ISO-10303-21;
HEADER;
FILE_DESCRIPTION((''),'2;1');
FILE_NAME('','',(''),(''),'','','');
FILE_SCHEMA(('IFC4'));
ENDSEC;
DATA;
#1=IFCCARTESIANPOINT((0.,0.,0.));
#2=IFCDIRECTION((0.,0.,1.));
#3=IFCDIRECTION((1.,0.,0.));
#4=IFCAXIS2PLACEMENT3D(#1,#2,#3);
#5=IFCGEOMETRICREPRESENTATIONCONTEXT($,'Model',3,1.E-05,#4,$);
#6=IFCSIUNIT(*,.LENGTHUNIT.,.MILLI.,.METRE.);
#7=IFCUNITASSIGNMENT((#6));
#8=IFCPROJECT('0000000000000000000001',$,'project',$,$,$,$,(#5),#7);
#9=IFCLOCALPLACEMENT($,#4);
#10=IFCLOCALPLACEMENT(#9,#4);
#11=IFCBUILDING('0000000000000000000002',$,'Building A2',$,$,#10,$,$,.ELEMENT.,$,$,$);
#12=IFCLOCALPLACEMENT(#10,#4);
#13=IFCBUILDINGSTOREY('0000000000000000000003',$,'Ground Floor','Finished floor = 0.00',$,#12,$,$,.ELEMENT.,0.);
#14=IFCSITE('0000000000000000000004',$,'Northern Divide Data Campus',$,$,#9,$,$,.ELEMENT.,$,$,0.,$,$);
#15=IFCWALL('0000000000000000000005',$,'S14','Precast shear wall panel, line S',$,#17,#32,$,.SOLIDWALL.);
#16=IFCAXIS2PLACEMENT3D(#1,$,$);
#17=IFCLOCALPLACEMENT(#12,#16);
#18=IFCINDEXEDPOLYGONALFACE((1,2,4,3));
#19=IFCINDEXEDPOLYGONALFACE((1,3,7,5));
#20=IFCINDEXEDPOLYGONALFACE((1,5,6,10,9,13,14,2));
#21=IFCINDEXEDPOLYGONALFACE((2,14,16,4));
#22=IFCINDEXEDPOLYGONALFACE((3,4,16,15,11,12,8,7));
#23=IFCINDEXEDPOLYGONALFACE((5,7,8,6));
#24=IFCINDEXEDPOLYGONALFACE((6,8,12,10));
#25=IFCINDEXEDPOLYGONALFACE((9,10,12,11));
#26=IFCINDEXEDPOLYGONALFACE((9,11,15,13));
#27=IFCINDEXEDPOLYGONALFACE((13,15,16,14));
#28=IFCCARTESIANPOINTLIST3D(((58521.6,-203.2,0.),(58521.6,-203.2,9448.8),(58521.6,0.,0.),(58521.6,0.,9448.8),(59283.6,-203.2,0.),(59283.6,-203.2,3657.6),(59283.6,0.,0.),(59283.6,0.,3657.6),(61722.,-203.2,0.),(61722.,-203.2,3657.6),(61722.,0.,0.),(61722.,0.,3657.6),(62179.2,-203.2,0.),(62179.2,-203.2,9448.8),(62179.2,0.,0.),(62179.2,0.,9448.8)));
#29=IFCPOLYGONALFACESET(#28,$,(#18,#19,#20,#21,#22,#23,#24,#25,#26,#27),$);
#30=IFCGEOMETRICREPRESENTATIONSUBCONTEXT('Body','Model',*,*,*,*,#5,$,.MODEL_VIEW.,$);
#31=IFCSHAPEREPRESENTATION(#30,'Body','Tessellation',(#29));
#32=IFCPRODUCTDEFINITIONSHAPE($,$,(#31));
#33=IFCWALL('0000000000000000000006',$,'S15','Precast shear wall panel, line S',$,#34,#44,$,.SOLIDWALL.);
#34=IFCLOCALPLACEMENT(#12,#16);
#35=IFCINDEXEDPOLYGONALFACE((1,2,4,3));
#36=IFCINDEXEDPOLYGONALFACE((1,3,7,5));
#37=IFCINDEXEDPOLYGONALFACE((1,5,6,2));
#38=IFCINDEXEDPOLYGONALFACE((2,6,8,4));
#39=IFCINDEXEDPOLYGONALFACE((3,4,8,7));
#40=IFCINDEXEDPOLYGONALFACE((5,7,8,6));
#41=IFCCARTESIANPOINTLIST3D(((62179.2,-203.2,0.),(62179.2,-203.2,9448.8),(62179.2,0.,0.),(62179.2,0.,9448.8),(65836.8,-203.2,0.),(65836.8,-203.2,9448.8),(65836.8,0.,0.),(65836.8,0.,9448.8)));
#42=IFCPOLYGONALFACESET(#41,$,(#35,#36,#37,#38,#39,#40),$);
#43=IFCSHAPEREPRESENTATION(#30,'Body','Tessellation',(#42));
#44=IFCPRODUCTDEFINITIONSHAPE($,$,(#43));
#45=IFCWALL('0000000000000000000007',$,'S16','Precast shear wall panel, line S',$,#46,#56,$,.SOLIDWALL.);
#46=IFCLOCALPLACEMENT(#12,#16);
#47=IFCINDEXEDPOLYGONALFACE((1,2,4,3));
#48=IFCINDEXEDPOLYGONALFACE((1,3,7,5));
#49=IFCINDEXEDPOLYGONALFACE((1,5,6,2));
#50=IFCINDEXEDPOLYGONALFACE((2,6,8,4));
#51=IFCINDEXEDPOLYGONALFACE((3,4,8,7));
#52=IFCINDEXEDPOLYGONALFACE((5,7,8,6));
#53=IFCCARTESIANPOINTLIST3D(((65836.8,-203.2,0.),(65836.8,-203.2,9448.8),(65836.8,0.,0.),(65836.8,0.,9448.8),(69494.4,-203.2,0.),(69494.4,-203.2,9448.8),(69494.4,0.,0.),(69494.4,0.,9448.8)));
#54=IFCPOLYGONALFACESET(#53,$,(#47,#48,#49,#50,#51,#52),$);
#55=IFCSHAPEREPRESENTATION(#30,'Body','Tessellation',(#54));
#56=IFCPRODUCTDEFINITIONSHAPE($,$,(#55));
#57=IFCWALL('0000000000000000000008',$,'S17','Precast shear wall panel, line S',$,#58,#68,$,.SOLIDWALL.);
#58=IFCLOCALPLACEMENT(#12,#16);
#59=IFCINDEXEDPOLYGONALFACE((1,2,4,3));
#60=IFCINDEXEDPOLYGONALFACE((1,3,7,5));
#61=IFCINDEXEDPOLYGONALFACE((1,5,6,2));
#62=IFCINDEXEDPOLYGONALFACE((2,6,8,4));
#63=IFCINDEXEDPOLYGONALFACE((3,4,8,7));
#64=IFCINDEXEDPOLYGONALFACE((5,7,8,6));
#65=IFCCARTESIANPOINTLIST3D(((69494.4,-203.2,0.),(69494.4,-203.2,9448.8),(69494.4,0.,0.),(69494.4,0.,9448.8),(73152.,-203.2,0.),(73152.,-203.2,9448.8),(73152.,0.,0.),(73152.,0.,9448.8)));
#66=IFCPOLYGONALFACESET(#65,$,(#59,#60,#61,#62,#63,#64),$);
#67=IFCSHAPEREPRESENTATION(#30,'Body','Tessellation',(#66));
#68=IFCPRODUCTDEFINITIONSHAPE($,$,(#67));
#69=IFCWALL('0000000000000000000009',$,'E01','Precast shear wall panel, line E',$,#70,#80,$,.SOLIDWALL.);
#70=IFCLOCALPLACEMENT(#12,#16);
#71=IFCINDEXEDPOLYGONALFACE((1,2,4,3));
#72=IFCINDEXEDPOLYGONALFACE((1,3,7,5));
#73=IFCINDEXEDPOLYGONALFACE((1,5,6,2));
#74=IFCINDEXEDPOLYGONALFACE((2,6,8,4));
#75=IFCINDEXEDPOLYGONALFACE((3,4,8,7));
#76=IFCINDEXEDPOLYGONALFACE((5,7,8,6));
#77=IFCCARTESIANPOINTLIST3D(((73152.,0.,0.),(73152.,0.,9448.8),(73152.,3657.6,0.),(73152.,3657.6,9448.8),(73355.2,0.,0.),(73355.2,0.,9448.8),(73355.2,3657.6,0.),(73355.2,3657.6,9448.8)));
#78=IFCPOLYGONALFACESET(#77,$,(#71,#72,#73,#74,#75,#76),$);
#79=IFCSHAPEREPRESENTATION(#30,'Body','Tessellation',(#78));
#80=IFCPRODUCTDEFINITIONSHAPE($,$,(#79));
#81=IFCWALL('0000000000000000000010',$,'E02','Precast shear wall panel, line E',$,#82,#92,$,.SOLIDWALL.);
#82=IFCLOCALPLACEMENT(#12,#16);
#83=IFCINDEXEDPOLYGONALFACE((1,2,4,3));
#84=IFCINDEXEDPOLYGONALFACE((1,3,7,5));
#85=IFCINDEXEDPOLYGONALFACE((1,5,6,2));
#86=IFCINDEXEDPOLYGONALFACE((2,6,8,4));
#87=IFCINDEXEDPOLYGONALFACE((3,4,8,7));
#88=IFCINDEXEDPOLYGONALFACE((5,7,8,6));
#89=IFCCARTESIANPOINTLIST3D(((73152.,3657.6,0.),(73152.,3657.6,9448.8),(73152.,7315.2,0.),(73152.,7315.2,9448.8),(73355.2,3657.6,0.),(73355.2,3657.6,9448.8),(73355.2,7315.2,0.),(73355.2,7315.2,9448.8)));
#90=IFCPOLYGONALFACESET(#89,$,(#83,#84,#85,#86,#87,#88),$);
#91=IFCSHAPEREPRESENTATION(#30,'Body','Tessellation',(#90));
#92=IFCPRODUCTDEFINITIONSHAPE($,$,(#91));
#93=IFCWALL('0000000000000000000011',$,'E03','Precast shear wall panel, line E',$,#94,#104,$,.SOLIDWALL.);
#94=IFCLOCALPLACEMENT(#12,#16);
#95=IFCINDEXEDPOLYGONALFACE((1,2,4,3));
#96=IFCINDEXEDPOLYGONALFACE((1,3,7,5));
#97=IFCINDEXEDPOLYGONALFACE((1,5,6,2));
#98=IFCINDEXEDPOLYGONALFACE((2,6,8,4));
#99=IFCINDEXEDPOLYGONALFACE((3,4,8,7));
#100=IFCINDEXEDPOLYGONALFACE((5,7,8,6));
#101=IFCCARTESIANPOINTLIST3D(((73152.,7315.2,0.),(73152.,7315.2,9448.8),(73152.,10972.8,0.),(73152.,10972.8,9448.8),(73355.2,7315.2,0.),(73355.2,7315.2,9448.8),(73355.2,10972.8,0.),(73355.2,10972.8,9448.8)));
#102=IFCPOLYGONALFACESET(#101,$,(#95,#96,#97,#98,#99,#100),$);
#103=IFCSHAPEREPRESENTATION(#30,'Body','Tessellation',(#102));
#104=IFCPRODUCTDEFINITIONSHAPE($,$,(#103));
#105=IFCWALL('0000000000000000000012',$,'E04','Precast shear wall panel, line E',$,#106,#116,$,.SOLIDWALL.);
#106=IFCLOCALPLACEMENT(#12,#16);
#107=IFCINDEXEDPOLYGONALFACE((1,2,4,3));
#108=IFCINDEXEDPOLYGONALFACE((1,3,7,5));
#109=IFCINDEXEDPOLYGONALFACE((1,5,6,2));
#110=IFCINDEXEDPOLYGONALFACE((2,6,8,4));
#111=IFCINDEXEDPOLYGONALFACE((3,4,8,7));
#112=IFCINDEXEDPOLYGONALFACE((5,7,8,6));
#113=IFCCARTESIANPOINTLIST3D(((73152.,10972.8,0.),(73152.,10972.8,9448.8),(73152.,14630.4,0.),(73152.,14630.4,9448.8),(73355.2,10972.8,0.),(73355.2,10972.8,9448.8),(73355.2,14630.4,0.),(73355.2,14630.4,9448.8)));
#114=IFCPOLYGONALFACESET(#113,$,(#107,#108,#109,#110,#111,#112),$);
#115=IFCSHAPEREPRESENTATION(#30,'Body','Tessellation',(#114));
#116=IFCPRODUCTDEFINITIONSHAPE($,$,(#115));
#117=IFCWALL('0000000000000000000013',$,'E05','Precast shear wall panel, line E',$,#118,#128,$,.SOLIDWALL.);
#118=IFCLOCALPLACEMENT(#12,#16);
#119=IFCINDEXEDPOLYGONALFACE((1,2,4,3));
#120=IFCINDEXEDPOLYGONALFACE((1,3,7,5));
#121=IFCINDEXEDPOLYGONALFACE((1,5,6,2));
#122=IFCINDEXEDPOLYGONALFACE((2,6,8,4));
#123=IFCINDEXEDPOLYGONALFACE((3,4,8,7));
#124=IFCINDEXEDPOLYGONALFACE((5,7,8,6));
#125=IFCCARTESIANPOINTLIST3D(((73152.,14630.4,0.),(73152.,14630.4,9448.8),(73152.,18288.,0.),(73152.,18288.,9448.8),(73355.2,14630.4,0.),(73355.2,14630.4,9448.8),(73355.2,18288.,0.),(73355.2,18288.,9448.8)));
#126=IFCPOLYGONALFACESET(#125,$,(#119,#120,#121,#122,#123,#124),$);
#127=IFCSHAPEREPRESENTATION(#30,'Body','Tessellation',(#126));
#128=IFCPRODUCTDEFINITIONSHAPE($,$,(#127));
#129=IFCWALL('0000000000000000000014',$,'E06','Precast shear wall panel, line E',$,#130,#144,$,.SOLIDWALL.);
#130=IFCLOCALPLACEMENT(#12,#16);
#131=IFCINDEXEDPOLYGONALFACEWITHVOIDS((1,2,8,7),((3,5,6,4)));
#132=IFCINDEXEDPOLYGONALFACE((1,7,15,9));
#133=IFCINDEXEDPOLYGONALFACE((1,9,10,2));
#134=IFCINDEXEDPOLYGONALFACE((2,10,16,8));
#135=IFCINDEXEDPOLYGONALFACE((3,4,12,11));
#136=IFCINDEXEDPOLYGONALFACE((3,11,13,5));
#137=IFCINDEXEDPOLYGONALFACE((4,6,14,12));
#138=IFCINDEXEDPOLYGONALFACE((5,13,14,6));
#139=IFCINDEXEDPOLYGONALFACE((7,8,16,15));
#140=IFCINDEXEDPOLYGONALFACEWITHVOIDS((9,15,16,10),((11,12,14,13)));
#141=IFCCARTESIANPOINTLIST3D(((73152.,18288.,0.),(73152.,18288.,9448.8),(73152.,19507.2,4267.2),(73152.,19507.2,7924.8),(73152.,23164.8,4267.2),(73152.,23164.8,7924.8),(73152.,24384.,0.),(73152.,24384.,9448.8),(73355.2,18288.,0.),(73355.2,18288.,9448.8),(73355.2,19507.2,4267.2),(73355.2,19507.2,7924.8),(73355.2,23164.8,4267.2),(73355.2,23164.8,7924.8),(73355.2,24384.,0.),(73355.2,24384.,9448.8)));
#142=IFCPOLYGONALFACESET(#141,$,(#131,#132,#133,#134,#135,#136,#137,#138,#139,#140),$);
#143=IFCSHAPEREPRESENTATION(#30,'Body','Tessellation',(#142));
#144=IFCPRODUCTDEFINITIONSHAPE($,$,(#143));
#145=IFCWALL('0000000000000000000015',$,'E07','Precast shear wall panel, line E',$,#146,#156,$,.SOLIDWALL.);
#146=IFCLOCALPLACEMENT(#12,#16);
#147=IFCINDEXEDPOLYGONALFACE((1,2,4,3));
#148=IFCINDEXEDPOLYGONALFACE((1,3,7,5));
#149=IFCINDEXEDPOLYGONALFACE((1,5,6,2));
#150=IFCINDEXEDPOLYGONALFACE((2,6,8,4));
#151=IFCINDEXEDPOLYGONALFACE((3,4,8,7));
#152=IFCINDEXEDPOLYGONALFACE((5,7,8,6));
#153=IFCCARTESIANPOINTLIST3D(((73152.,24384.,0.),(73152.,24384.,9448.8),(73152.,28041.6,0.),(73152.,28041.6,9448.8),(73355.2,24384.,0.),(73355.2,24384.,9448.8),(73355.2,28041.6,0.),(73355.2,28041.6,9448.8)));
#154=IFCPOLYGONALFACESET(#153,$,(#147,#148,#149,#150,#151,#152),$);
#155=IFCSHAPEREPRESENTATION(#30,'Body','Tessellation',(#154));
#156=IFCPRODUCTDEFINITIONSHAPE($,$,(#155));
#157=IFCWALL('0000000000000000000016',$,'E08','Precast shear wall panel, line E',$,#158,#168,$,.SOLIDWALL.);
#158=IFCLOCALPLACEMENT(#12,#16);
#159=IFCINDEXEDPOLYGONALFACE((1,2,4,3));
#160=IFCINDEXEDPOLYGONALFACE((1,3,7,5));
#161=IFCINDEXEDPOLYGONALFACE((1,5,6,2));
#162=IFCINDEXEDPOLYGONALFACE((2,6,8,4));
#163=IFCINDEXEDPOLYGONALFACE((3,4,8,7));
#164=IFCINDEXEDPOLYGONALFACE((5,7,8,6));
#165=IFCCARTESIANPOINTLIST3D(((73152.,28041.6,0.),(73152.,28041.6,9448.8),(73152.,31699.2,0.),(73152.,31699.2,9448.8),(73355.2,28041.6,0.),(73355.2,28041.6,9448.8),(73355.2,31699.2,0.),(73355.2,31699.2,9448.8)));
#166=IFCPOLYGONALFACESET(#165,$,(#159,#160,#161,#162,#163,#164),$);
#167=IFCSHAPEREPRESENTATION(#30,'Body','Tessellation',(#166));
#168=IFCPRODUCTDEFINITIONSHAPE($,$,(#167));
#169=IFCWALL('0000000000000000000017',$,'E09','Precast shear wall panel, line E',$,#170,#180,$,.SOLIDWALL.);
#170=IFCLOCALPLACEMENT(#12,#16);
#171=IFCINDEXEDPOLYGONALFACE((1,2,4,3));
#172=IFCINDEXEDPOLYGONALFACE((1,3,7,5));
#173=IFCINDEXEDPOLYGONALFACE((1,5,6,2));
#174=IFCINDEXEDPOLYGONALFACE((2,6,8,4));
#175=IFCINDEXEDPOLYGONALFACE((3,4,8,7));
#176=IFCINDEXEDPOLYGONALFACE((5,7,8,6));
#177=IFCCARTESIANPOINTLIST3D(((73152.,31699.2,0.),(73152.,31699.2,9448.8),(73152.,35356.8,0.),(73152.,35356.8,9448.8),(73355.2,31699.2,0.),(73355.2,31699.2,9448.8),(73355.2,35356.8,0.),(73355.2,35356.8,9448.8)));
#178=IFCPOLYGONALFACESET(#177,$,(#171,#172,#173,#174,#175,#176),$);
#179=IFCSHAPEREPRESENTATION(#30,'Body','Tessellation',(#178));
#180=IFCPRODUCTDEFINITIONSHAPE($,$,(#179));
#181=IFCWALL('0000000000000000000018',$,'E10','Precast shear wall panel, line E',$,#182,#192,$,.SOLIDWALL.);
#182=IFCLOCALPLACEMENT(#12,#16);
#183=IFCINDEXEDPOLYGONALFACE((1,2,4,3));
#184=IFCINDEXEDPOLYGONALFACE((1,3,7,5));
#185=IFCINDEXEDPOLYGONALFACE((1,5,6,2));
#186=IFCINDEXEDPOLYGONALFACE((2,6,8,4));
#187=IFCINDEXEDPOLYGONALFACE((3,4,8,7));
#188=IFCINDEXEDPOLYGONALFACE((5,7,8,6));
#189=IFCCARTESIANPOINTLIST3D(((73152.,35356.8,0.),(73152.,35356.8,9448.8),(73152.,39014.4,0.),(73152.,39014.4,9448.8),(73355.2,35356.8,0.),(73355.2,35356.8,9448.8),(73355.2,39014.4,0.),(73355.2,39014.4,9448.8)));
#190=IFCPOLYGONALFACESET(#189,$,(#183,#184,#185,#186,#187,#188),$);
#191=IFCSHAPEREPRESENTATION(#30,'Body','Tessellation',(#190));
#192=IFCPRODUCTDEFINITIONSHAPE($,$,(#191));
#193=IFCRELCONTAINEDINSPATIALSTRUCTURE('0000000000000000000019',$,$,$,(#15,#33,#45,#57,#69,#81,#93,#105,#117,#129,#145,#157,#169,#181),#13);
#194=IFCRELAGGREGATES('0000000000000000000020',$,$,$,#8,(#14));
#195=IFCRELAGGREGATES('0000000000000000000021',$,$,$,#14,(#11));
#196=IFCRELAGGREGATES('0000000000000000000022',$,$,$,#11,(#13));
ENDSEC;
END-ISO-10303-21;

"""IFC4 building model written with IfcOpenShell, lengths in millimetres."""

from ifc_helpers import new_model, si_unit, frame, origin, origin_with_axes, place, context, subcontext, project, spatial, polyline, outline, extrude, element, save


model = new_model("IFC4")

# Units and contexts
model_context = context("Model", 3, precision=1e-05, world=origin_with_axes())
body_context = subcontext(model_context, "Body", "Model", "MODEL_VIEW")
ifc_project = project(units=[si_unit("LENGTHUNIT", "METRE", prefix="MILLI")], contexts=[model_context])

# Site, building, storey
site_placement = place(None, origin_with_axes())
site = spatial("IfcSite", under=ifc_project, at=site_placement, Name="Northern Divide Data Campus", CompositionType="ELEMENT", RefElevation=0.0)
building_placement = place(site_placement, origin_with_axes())
building = spatial("IfcBuilding", under=site, at=building_placement, Name="Building A2", CompositionType="ELEMENT")
storey_placement = place(building_placement, origin_with_axes())
storey = spatial("IfcBuildingStorey", under=building, at=storey_placement, Name="Ground Floor", Description="Finished floor = 0.00", CompositionType="ELEMENT", Elevation=0.0)

# Wall, opening
wall_1_placement = place(storey_placement, origin_with_axes())
wall_1 = element("IfcWall", 1, at=wall_1_placement, inside=storey, Name="S14", Description="Precast shear wall panel, line S", PredefinedType="SOLIDWALL", context=body_context, shape_type="SweptSolid", body=[
    extrude(outline(polyline([(58521.6, -203.2), (62179.2, -203.2), (62179.2, 0.0), (58521.6, 0.0), (58521.6, -203.2)])), origin(), (0.0, 0.0, 1.0), 9448.8),
])
opening_1_placement = place(storey_placement, origin_with_axes())
element("IfcOpeningElement", 2, at=opening_1_placement, cuts=wall_1, PredefinedType="OPENING", context=body_context, shape_type="SweptSolid", body=[
    extrude(outline(polyline([(59283.6, -203.2), (61722.0, -203.2), (61722.0, 0.0), (59283.6, 0.0), (59283.6, -203.2)])), origin_with_axes(), (0.0, 0.0, 1.0), 3657.6),
])

# Walls
wall_2_placement = place(storey_placement, origin_with_axes())
element("IfcWall", 3, at=wall_2_placement, inside=storey, Name="S15", Description="Precast shear wall panel, line S", PredefinedType="SOLIDWALL", context=body_context, shape_type="SweptSolid", body=[
    extrude(outline(polyline([(62179.2, -203.2), (65836.8, -203.2), (65836.8, 0.0), (62179.2, 0.0), (62179.2, -203.2)])), origin(), (0.0, 0.0, 1.0), 9448.8),
])
wall_3_placement = place(storey_placement, origin_with_axes())
element("IfcWall", 4, at=wall_3_placement, inside=storey, Name="S16", Description="Precast shear wall panel, line S", PredefinedType="SOLIDWALL", context=body_context, shape_type="SweptSolid", body=[
    extrude(outline(polyline([(65836.8, -203.2), (69494.4, -203.2), (69494.4, 0.0), (65836.8, 0.0), (65836.8, -203.2)])), origin(), (0.0, 0.0, 1.0), 9448.8),
])
wall_4_placement = place(storey_placement, origin_with_axes())
element("IfcWall", 5, at=wall_4_placement, inside=storey, Name="S17", Description="Precast shear wall panel, line S", PredefinedType="SOLIDWALL", context=body_context, shape_type="SweptSolid", body=[
    extrude(outline(polyline([(69494.4, -203.2), (73152.0, -203.2), (73152.0, 0.0), (69494.4, 0.0), (69494.4, -203.2)])), origin(), (0.0, 0.0, 1.0), 9448.8),
])
wall_5_placement = place(storey_placement, origin_with_axes())
element("IfcWall", 6, at=wall_5_placement, inside=storey, Name="E01", Description="Precast shear wall panel, line E", PredefinedType="SOLIDWALL", context=body_context, shape_type="SweptSolid", body=[
    extrude(outline(polyline([(73152.0, 0.0), (73355.2, 0.0), (73355.2, 3657.6), (73152.0, 3657.6), (73152.0, 0.0)])), origin(), (0.0, 0.0, 1.0), 9448.8),
])
wall_6_placement = place(storey_placement, origin_with_axes())
element("IfcWall", 7, at=wall_6_placement, inside=storey, Name="E02", Description="Precast shear wall panel, line E", PredefinedType="SOLIDWALL", context=body_context, shape_type="SweptSolid", body=[
    extrude(outline(polyline([(73152.0, 3657.6), (73355.2, 3657.6), (73355.2, 7315.2), (73152.0, 7315.2), (73152.0, 3657.6)])), origin(), (0.0, 0.0, 1.0), 9448.8),
])
wall_7_placement = place(storey_placement, origin_with_axes())
element("IfcWall", 8, at=wall_7_placement, inside=storey, Name="E03", Description="Precast shear wall panel, line E", PredefinedType="SOLIDWALL", context=body_context, shape_type="SweptSolid", body=[
    extrude(outline(polyline([(73152.0, 7315.2), (73355.2, 7315.2), (73355.2, 10972.8), (73152.0, 10972.8), (73152.0, 7315.2)])), origin(), (0.0, 0.0, 1.0), 9448.8),
])
wall_8_placement = place(storey_placement, origin_with_axes())
element("IfcWall", 9, at=wall_8_placement, inside=storey, Name="E04", Description="Precast shear wall panel, line E", PredefinedType="SOLIDWALL", context=body_context, shape_type="SweptSolid", body=[
    extrude(outline(polyline([(73152.0, 10972.8), (73355.2, 10972.8), (73355.2, 14630.4), (73152.0, 14630.4), (73152.0, 10972.8)])), origin(), (0.0, 0.0, 1.0), 9448.8),
])
wall_9_placement = place(storey_placement, origin_with_axes())
element("IfcWall", 10, at=wall_9_placement, inside=storey, Name="E05", Description="Precast shear wall panel, line E", PredefinedType="SOLIDWALL", context=body_context, shape_type="SweptSolid", body=[
    extrude(outline(polyline([(73152.0, 14630.4), (73355.2, 14630.4), (73355.2, 18288.0), (73152.0, 18288.0), (73152.0, 14630.4)])), origin(), (0.0, 0.0, 1.0), 9448.8),
])

# Wall, opening
wall_10_placement = place(storey_placement, origin_with_axes())
wall_10 = element("IfcWall", 11, at=wall_10_placement, inside=storey, Name="E06", Description="Precast shear wall panel, line E", PredefinedType="SOLIDWALL", context=body_context, shape_type="SweptSolid", body=[
    extrude(outline(polyline([(73152.0, 18288.0), (73355.2, 18288.0), (73355.2, 24384.0), (73152.0, 24384.0), (73152.0, 18288.0)])), origin(), (0.0, 0.0, 1.0), 9448.8),
])
opening_2_placement = place(storey_placement, origin_with_axes())
element("IfcOpeningElement", 12, at=opening_2_placement, cuts=wall_10, PredefinedType="OPENING", context=body_context, shape_type="SweptSolid", body=[
    extrude(outline(polyline([(73152.0, 19507.2), (73355.2, 19507.2), (73355.2, 23164.8), (73152.0, 23164.8), (73152.0, 19507.2)])), frame((0.0, 0.0, 4267.2), z_axis=(0.0, 0.0, 1.0), x_axis=(1.0, 0.0, 0.0)), (0.0, 0.0, 1.0), 3657.6),
])

# Walls
wall_11_placement = place(storey_placement, origin_with_axes())
element("IfcWall", 13, at=wall_11_placement, inside=storey, Name="E07", Description="Precast shear wall panel, line E", PredefinedType="SOLIDWALL", context=body_context, shape_type="SweptSolid", body=[
    extrude(outline(polyline([(73152.0, 24384.0), (73355.2, 24384.0), (73355.2, 28041.6), (73152.0, 28041.6), (73152.0, 24384.0)])), origin(), (0.0, 0.0, 1.0), 9448.8),
])
wall_12_placement = place(storey_placement, origin_with_axes())
element("IfcWall", 14, at=wall_12_placement, inside=storey, Name="E08", Description="Precast shear wall panel, line E", PredefinedType="SOLIDWALL", context=body_context, shape_type="SweptSolid", body=[
    extrude(outline(polyline([(73152.0, 28041.6), (73355.2, 28041.6), (73355.2, 31699.2), (73152.0, 31699.2), (73152.0, 28041.6)])), origin(), (0.0, 0.0, 1.0), 9448.8),
])
wall_13_placement = place(storey_placement, origin_with_axes())
element("IfcWall", 15, at=wall_13_placement, inside=storey, Name="E09", Description="Precast shear wall panel, line E", PredefinedType="SOLIDWALL", context=body_context, shape_type="SweptSolid", body=[
    extrude(outline(polyline([(73152.0, 31699.2), (73355.2, 31699.2), (73355.2, 35356.8), (73152.0, 35356.8), (73152.0, 31699.2)])), origin(), (0.0, 0.0, 1.0), 9448.8),
])
wall_14_placement = place(storey_placement, origin_with_axes())
element("IfcWall", 16, at=wall_14_placement, inside=storey, Name="E10", Description="Precast shear wall panel, line E", PredefinedType="SOLIDWALL", context=body_context, shape_type="SweptSolid", body=[
    extrude(outline(polyline([(73152.0, 35356.8), (73355.2, 35356.8), (73355.2, 39014.4), (73152.0, 39014.4), (73152.0, 35356.8)])), origin(), (0.0, 0.0, 1.0), 9448.8),
])

save(model, "model.ifc")
